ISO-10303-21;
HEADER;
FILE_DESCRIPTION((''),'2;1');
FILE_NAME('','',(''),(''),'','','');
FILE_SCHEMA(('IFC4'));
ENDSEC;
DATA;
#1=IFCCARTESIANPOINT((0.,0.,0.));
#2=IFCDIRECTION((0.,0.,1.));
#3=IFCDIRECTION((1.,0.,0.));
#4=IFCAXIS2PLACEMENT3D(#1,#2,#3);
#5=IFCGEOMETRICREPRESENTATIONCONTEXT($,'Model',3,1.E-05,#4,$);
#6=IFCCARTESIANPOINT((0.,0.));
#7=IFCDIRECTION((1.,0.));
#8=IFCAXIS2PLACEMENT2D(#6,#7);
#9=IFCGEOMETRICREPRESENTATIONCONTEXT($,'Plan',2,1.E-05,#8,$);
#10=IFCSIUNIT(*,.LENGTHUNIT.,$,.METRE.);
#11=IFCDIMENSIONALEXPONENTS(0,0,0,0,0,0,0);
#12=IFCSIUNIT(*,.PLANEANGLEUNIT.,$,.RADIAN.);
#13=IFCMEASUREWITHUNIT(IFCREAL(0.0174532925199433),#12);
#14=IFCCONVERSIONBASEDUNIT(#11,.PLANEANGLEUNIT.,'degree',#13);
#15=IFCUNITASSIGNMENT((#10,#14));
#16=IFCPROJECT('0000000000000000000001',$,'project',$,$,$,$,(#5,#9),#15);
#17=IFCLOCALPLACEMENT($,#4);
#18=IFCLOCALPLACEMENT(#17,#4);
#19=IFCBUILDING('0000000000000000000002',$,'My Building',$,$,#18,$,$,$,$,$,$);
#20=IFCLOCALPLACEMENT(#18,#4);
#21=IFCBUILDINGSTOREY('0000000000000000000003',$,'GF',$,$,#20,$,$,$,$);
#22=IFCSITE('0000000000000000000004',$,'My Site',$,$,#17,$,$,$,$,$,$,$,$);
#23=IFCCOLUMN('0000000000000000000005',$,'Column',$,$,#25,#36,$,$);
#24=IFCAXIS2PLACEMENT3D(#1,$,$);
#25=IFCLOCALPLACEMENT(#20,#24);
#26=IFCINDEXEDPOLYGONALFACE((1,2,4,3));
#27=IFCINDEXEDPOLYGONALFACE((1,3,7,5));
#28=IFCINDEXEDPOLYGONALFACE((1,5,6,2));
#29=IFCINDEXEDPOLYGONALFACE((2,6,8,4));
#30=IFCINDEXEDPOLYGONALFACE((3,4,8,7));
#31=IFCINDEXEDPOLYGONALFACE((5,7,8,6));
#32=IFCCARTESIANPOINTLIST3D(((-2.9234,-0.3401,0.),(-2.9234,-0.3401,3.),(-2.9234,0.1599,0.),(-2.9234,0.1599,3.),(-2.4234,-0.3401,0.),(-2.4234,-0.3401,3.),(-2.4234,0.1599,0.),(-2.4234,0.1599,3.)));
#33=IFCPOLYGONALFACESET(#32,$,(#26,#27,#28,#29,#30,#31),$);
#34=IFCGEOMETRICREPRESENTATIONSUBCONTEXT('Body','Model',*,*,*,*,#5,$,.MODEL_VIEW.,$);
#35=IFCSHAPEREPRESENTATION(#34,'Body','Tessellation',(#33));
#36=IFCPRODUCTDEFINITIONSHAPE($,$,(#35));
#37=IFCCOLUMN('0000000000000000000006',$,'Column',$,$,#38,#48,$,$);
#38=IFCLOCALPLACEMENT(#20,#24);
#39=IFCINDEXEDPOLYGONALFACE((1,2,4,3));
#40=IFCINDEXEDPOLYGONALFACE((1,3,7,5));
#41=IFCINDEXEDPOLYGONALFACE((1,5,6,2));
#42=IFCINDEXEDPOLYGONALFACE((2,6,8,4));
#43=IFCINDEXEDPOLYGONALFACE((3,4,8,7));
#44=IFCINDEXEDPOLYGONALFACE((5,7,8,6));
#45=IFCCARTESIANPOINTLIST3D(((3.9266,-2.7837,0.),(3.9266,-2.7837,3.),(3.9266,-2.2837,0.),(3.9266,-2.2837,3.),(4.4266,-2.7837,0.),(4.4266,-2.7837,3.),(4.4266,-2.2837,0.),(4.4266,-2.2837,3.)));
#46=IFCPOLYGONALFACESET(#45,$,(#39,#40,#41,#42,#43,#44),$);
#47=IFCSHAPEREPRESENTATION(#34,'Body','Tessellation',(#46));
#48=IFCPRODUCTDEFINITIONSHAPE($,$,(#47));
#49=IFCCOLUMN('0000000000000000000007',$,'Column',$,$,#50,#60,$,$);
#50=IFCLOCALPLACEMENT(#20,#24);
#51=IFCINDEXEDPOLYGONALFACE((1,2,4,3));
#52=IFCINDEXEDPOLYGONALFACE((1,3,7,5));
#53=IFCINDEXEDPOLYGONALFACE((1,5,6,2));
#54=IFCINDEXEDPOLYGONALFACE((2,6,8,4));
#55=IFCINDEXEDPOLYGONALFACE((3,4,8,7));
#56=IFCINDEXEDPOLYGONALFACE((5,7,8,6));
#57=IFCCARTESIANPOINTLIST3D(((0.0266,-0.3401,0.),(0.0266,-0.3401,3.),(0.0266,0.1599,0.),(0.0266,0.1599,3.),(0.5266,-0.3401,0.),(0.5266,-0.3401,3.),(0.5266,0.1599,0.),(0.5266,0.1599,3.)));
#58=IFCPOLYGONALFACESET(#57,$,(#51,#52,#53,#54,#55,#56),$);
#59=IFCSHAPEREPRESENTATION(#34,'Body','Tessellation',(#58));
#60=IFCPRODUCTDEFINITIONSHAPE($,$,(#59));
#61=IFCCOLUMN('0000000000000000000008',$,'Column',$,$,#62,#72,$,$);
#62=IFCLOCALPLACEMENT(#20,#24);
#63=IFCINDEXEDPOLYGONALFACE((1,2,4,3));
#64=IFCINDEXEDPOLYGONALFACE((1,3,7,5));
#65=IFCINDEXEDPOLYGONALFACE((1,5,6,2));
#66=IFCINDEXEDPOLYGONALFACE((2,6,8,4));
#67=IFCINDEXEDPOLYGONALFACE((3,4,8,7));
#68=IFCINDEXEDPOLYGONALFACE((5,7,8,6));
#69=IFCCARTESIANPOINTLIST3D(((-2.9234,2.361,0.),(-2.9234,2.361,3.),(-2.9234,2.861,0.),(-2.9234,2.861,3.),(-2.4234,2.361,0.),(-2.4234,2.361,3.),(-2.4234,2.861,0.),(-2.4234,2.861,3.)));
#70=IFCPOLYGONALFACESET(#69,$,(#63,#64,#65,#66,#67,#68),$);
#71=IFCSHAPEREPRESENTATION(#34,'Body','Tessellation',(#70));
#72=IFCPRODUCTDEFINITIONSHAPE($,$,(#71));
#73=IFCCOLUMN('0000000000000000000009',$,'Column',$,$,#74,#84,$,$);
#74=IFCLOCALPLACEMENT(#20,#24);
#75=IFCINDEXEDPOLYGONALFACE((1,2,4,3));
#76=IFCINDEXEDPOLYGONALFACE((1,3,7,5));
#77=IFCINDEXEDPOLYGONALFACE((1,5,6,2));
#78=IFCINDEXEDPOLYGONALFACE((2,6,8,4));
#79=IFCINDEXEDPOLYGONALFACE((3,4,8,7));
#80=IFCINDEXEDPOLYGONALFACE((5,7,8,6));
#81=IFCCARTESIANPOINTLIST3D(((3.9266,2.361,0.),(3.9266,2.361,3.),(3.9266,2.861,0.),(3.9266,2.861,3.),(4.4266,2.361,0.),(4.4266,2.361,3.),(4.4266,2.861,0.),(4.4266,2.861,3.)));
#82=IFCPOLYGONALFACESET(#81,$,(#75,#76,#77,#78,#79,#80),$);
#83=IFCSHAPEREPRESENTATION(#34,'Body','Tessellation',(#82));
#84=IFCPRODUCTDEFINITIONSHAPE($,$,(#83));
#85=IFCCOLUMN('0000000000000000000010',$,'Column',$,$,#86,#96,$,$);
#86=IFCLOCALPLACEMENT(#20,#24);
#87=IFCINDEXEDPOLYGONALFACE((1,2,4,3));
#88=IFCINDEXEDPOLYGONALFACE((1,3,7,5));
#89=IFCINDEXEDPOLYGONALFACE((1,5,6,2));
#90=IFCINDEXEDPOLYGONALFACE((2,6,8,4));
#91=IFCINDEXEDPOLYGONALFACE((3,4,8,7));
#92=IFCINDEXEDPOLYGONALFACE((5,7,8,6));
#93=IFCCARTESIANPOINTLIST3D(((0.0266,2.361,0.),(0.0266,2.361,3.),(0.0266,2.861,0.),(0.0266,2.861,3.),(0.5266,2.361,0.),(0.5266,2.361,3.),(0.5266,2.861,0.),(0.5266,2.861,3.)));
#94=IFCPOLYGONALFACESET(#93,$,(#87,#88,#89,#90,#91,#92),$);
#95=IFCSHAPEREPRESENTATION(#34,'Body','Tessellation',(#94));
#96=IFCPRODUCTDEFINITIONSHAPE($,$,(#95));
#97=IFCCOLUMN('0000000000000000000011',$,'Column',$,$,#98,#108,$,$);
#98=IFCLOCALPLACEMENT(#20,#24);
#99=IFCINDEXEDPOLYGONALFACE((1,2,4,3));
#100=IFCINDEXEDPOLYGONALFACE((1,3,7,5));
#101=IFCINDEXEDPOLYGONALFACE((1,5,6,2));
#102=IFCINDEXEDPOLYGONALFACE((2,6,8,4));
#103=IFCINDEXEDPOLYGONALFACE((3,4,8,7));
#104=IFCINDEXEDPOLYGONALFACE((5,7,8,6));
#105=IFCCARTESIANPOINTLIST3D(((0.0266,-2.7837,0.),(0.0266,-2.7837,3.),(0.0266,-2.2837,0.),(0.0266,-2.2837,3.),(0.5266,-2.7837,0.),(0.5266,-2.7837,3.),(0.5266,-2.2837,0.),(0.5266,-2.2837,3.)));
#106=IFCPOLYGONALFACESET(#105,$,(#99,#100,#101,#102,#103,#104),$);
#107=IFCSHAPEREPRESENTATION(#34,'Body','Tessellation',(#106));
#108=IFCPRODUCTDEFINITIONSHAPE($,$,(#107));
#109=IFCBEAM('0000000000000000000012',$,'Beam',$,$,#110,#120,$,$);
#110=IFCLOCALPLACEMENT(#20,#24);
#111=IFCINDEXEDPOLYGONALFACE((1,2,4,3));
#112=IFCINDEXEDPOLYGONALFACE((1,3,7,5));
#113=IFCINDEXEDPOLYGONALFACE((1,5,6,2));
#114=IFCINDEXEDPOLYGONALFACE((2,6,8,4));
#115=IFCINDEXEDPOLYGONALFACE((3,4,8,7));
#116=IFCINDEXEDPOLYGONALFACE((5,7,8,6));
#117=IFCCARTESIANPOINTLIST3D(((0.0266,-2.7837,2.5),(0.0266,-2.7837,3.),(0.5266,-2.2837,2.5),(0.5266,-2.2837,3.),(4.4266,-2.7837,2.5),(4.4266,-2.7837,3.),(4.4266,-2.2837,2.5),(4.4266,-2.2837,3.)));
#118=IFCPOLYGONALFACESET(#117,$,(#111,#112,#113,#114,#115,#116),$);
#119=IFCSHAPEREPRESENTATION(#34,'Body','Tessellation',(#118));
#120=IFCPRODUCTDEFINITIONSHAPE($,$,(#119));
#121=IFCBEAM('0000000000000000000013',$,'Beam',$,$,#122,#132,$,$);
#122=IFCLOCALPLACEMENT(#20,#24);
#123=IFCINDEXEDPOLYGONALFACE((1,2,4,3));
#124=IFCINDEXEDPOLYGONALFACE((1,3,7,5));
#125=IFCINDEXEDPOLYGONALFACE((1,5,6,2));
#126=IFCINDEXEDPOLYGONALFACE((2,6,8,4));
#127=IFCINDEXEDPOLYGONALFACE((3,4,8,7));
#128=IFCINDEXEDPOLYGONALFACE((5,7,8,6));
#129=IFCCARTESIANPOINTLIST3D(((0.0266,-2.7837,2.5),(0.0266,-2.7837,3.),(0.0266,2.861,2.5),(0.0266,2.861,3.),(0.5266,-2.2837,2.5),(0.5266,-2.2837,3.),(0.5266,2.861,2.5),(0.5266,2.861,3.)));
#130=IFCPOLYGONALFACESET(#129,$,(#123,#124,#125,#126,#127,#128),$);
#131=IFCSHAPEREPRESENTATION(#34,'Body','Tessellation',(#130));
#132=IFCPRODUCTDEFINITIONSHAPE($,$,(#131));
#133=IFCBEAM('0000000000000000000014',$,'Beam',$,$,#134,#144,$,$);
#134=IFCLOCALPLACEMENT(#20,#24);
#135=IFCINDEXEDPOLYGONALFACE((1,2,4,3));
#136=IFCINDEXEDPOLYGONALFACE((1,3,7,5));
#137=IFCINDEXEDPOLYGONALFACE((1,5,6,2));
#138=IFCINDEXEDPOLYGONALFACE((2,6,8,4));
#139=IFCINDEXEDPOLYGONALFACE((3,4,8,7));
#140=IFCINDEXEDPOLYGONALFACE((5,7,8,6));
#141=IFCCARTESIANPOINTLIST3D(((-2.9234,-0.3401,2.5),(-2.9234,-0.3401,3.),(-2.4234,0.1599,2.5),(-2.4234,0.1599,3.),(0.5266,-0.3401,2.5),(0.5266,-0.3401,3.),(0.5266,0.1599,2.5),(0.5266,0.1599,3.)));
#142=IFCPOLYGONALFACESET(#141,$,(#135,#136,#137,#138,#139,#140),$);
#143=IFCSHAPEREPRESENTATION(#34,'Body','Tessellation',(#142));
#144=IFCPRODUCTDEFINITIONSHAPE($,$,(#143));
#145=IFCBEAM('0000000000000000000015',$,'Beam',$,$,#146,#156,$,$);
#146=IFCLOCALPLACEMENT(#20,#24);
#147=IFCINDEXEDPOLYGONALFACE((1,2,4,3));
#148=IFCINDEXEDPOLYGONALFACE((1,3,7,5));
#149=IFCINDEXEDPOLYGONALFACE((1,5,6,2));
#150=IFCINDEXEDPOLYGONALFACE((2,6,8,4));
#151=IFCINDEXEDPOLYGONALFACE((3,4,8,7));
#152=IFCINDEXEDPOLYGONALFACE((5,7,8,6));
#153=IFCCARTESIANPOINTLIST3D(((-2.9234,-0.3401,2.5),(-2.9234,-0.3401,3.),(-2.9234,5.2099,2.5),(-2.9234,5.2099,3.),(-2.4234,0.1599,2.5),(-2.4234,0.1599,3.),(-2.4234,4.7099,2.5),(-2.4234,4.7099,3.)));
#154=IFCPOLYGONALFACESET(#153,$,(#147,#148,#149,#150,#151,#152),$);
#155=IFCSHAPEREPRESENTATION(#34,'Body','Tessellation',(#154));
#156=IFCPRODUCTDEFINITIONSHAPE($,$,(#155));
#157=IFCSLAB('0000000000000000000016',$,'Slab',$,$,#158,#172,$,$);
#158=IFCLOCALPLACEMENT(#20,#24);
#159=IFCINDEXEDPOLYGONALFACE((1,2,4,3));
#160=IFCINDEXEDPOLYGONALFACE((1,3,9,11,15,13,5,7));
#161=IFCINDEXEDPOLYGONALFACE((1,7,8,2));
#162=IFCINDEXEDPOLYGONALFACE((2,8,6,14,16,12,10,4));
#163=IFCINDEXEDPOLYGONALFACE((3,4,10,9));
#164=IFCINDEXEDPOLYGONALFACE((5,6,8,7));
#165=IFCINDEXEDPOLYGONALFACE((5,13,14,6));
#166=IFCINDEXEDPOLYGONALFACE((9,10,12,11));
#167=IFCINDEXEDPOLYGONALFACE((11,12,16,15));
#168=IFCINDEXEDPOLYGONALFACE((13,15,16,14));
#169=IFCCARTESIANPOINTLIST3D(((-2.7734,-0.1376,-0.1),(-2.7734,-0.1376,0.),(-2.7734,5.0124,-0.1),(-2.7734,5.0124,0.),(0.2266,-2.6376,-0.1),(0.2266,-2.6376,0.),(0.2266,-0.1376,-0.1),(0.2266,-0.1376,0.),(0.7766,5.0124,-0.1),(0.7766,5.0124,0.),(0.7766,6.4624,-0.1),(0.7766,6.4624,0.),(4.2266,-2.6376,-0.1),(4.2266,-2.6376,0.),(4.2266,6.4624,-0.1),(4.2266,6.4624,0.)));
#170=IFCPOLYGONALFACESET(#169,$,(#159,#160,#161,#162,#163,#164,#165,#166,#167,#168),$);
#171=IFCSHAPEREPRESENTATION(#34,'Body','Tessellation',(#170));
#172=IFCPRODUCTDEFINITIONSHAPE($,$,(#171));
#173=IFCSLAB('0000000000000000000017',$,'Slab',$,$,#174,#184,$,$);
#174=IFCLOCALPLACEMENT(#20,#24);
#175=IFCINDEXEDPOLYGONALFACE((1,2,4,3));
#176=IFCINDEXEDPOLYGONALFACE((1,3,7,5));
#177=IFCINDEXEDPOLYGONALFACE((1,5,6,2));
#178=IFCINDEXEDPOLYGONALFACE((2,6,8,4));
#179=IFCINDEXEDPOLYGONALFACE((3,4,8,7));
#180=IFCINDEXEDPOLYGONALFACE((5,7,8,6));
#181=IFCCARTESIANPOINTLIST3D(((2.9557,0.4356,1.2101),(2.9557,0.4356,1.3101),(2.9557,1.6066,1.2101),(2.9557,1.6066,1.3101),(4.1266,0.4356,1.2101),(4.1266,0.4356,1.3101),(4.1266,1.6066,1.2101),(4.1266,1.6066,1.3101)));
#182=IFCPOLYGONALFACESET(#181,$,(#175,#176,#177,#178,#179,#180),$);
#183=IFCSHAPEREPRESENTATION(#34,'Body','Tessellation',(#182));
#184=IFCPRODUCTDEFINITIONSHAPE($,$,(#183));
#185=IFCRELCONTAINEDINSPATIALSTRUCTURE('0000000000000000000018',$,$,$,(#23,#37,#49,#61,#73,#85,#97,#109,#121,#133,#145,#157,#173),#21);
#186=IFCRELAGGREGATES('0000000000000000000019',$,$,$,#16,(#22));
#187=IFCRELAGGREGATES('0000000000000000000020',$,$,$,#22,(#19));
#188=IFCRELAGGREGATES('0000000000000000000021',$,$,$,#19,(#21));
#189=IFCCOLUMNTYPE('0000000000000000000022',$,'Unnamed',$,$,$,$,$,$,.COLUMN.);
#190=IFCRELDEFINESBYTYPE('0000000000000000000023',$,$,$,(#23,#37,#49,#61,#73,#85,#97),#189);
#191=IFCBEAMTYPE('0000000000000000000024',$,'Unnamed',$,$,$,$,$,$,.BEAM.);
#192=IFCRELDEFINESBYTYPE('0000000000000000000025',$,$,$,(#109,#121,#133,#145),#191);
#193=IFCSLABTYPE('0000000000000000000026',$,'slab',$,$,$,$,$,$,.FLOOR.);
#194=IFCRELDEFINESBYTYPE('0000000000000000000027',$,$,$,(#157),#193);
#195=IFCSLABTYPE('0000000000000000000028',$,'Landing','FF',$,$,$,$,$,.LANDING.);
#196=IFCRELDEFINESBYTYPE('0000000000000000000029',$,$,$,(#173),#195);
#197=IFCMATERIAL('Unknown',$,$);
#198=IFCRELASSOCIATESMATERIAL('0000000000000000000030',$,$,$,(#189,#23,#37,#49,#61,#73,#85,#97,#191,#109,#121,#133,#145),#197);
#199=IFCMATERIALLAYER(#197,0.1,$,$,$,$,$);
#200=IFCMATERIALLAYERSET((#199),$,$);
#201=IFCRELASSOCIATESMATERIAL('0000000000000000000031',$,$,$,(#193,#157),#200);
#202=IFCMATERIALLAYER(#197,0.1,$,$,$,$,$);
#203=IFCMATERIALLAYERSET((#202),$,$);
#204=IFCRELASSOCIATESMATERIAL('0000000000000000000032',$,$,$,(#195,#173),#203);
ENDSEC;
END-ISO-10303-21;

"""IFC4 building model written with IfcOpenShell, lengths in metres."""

from ifc_helpers import new_model, entity, si_unit, converted_unit, frame, origin_with_axes, origin_2d_with_axis, place, context, subcontext, project, spatial, indexed_curve, rectangle, outline, extrude, clip, halfspace, material, layer, layer_set, layer_usage, material_profile, profile_set, profile_usage, type_object, element, save


model = new_model("IFC4")

# Units and contexts
model_context = context("Model", 3, precision=1e-05, world=origin_with_axes())
plan_context = context("Plan", 2, precision=1e-05, world=origin_2d_with_axis())
body_context_1 = subcontext(model_context, "Body", "Model", "MODEL_VIEW")
ifc_project = project(units=[si_unit("LENGTHUNIT", "METRE"), converted_unit("PLANEANGLEUNIT", "degree", entity("IfcReal", 0.0174532925199433), si_unit("PLANEANGLEUNIT", "RADIAN"), dimensions=[0, 0, 0, 0, 0, 0, 0])], contexts=[model_context, plan_context])

# Site, building, storey
site_placement = place(None, origin_with_axes())
site = spatial("IfcSite", under=ifc_project, at=site_placement, Name="My Site")
building_placement = place(site_placement, origin_with_axes())
building = spatial("IfcBuilding", under=site, at=building_placement, Name="My Building")
storey_placement = place(building_placement, origin_with_axes())
storey = spatial("IfcBuildingStorey", under=building, at=storey_placement, Name="GF")

# Columns
ifc_material_1 = material(Name="Unknown")
ifc_material_profile_1 = material_profile(ifc_material_1, rectangle(XDim=0.5, YDim=0.5))
ifc_profile_set_1 = profile_set([ifc_material_profile_1])
ifc_profile_usage_1 = profile_usage(ifc_profile_set_1, cardinal=5)
column_type = type_object("IfcColumnType", Name="Unnamed", PredefinedType="COLUMN", material=ifc_profile_set_1)
column_1_placement = place(storey_placement, frame((-2.6734, -0.0901, 0.0), z_axis=(0.0, 0.0, 1.0), x_axis=(1.0, 0.0, 0.0)))
element("IfcColumn", 1, at=column_1_placement, inside=storey, type_object=column_type, material=ifc_profile_usage_1, Name="Column", context=body_context_1, shape_type="SweptSolid", body=[
    extrude(rectangle(XDim=0.5, YDim=0.5), origin_with_axes(), (0.0, 0.0, 1.0), 3.0),
])
ifc_profile_usage_2 = profile_usage(ifc_profile_set_1, cardinal=5)
column_2_placement = place(storey_placement, frame((4.1766, -2.5337, 0.0), z_axis=(0.0, 0.0, 1.0), x_axis=(1.0, 0.0, 0.0)))
element("IfcColumn", 2, at=column_2_placement, inside=storey, type_object=column_type, material=ifc_profile_usage_2, Name="Column", context=body_context_1, shape_type="SweptSolid", body=[
    extrude(rectangle(XDim=0.5, YDim=0.5), origin_with_axes(), (0.0, 0.0, 1.0), 3.0),
])
ifc_profile_usage_3 = profile_usage(ifc_profile_set_1, cardinal=5)
column_3_placement = place(storey_placement, frame((0.2766, -0.0901, 0.0), z_axis=(0.0, 0.0, 1.0), x_axis=(1.0, 0.0, 0.0)))
element("IfcColumn", 3, at=column_3_placement, inside=storey, type_object=column_type, material=ifc_profile_usage_3, Name="Column", context=body_context_1, shape_type="SweptSolid", body=[
    extrude(rectangle(XDim=0.5, YDim=0.5), origin_with_axes(), (0.0, 0.0, 1.0), 3.0),
])
ifc_profile_usage_4 = profile_usage(ifc_profile_set_1, cardinal=5)
column_4_placement = place(storey_placement, frame((-2.6734, 2.611, 0.0), z_axis=(0.0, 0.0, 1.0), x_axis=(1.0, 0.0, 0.0)))
element("IfcColumn", 4, at=column_4_placement, inside=storey, type_object=column_type, material=ifc_profile_usage_4, Name="Column", context=body_context_1, shape_type="SweptSolid", body=[
    extrude(rectangle(XDim=0.5, YDim=0.5), origin_with_axes(), (0.0, 0.0, 1.0), 3.0),
])
ifc_profile_usage_5 = profile_usage(ifc_profile_set_1, cardinal=5)
column_5_placement = place(storey_placement, frame((4.1766, 2.611, 0.0), z_axis=(0.0, 0.0, 1.0), x_axis=(1.0, 0.0, 0.0)))
element("IfcColumn", 5, at=column_5_placement, inside=storey, type_object=column_type, material=ifc_profile_usage_5, Name="Column", context=body_context_1, shape_type="SweptSolid", body=[
    extrude(rectangle(XDim=0.5, YDim=0.5), origin_with_axes(), (0.0, 0.0, 1.0), 3.0),
])
ifc_profile_usage_6 = profile_usage(ifc_profile_set_1, cardinal=5)
column_6_placement = place(storey_placement, frame((0.2766, 2.611, 0.0), z_axis=(0.0, 0.0, 1.0), x_axis=(1.0, 0.0, 0.0)))
element("IfcColumn", 6, at=column_6_placement, inside=storey, type_object=column_type, material=ifc_profile_usage_6, Name="Column", context=body_context_1, shape_type="SweptSolid", body=[
    extrude(rectangle(XDim=0.5, YDim=0.5), origin_with_axes(), (0.0, 0.0, 1.0), 3.0),
])
ifc_profile_usage_7 = profile_usage(ifc_profile_set_1, cardinal=5)
column_7_placement = place(storey_placement, frame((0.2766, -2.5337, 0.0), z_axis=(0.0, 0.0, 1.0), x_axis=(1.0, 0.0, 0.0)))
element("IfcColumn", 7, at=column_7_placement, inside=storey, type_object=column_type, material=ifc_profile_usage_7, Name="Column", context=body_context_1, shape_type="SweptSolid", body=[
    extrude(rectangle(XDim=0.5, YDim=0.5), origin_with_axes(), (0.0, 0.0, 1.0), 3.0),
])

# Beams
ifc_material_profile_2 = material_profile(ifc_material_1, rectangle(XDim=0.5, YDim=0.5))
ifc_profile_set_2 = profile_set([ifc_material_profile_2])
ifc_profile_usage_8 = profile_usage(ifc_profile_set_2, cardinal=7)
beam_type = type_object("IfcBeamType", Name="Unnamed", PredefinedType="BEAM", material=ifc_profile_set_2)
beam_1_placement = place(storey_placement, frame((4.4266, -2.7837, 3.0), z_axis=(-1.0, 0.0, 0.0), x_axis=(0.0, -1.0, 0.0)))
element("IfcBeam", 8, at=beam_1_placement, inside=storey, type_object=beam_type, material=ifc_profile_usage_8, Name="Beam", context=body_context_1, shape_type="Clipping", body=[
    clip(extrude(rectangle(XDim=0.5, YDim=0.5), frame((-0.25, -0.25, 0.0), z_axis=(0.0, 0.0, 1.0), x_axis=(1.0, 0.0, 0.0)), (0.0, 0.0, 1.0), 4.4), halfspace(frame((0.0, -3.0, 4.4), z_axis=(-0.707107, 0.0, 0.707107), x_axis=(0.0, 1.0, 0.0)), False)),
])
ifc_profile_usage_9 = profile_usage(ifc_profile_set_2, cardinal=7)
beam_2_placement = place(storey_placement, frame((0.0266, -2.7837, 3.0), z_axis=(0.0, 1.0, 0.0), x_axis=(-1.0, 0.0, 0.0)))
element("IfcBeam", 9, at=beam_2_placement, inside=storey, type_object=beam_type, material=ifc_profile_usage_9, Name="Beam", context=body_context_1, shape_type="Clipping", body=[
    clip(extrude(rectangle(XDim=0.5, YDim=0.5), frame((-0.25, -0.25, 0.0), z_axis=(0.0, 0.0, 1.0), x_axis=(1.0, 0.0, 0.0)), (0.0, 0.0, 1.0), 5.6448), halfspace(frame((0.0, -3.0, 0.0), z_axis=(-0.707107, 0.0, -0.707107), x_axis=(0.0, 1.0, 0.0)), False)),
])
ifc_profile_usage_10 = profile_usage(ifc_profile_set_2, cardinal=7)
beam_3_placement = place(storey_placement, frame((0.5266, -0.3401, 3.0), z_axis=(-1.0, 0.0, 0.0), x_axis=(0.0, -1.0, 0.0)))
element("IfcBeam", 10, at=beam_3_placement, inside=storey, type_object=beam_type, material=ifc_profile_usage_10, Name="Beam", context=body_context_1, shape_type="Clipping", body=[
    clip(extrude(rectangle(XDim=0.5, YDim=0.5), frame((-0.25, -0.25, 0.0), z_axis=(0.0, 0.0, 1.0), x_axis=(1.0, 0.0, 0.0)), (0.0, 0.0, 1.0), 3.45), halfspace(frame((0.0, -3.0, 3.45), z_axis=(-0.707107, 0.0, 0.707107), x_axis=(0.0, 1.0, 0.0)), False)),
])
ifc_profile_usage_11 = profile_usage(ifc_profile_set_2, cardinal=7)
beam_4_placement = place(storey_placement, frame((-2.9234, -0.3401, 3.0), z_axis=(0.0, 1.0, 0.0), x_axis=(-1.0, 0.0, 0.0)))
element("IfcBeam", 11, at=beam_4_placement, inside=storey, type_object=beam_type, material=ifc_profile_usage_11, Name="Beam", context=body_context_1, shape_type="Clipping", body=[
    clip(clip(extrude(rectangle(XDim=0.5, YDim=0.5), frame((-0.25, -0.25, 0.0), z_axis=(0.0, 0.0, 1.0), x_axis=(1.0, 0.0, 0.0)), (0.0, 0.0, 1.0), 5.55), halfspace(frame((0.0, -3.0, 5.55), z_axis=(-0.707107, 0.0, 0.707107), x_axis=(0.0, 1.0, 0.0)), False)), halfspace(frame((0.0, -3.0, 0.0), z_axis=(-0.707107, 0.0, -0.707107), x_axis=(0.0, 1.0, 0.0)), False)),
])

# Slabs
ifc_layer_1 = layer(ifc_material_1, 0.1)
ifc_layer_set_1 = layer_set([ifc_layer_1])
ifc_layer_usage_1 = layer_usage(ifc_layer_set_1, "AXIS3", "POSITIVE", -0.1)
slab_type_1 = type_object("IfcSlabType", Name="slab", PredefinedType="FLOOR", material=ifc_layer_set_1)
slab_1_placement = place(storey_placement, frame((4.2266, -2.6376, 0.0), z_axis=(0.0, 0.0, 1.0), x_axis=(1.0, 0.0, 0.0)))
element("IfcSlab", 12, at=slab_1_placement, inside=storey, type_object=slab_type_1, material=ifc_layer_usage_1, Name="Slab", context=body_context_1, shape_type="SweptSolid", body=[
    extrude(outline(indexed_curve([(0.0, 0.0), (0.0, 9.1), (-3.45, 9.1), (-3.45, 7.65), (-7.0, 7.65), (-7.0, 2.5), (-4.0, 2.5), (-4.0, 0.0), (0.0, 0.0)])), frame((0.0, 0.0, -0.1), z_axis=(0.0, 0.0, 1.0), x_axis=(1.0, 0.0, 0.0)), (0.0, 0.0, 1.0), 0.1),
])
ifc_layer_2 = layer(ifc_material_1, 0.1)
ifc_layer_set_2 = layer_set([ifc_layer_2])
ifc_layer_usage_2 = layer_usage(ifc_layer_set_2, "AXIS3", "POSITIVE", -0.1)
slab_type_2 = type_object("IfcSlabType", Name="Landing", Description="FF", PredefinedType="LANDING", material=ifc_layer_set_2)
slab_2_placement = place(storey_placement, frame((4.1266, 0.4356, 1.3101), z_axis=(0.0, 0.0, 1.0), x_axis=(1.0, 0.0, 0.0)))
element("IfcSlab", 13, at=slab_2_placement, inside=storey, type_object=slab_type_2, material=ifc_layer_usage_2, Name="Slab", context=body_context_1, shape_type="SweptSolid", body=[
    extrude(outline(indexed_curve([(0.0, 0.0), (-1.1709, 0.0), (-1.1709, 1.171), (0.0, 1.171), (0.0, 0.0)])), frame((0.0, 0.0, -0.1), z_axis=(0.0, 0.0, 1.0), x_axis=(1.0, 0.0, 0.0)), (0.0, 0.0, 1.0), 0.1),
])

save(model, "model.ifc")
